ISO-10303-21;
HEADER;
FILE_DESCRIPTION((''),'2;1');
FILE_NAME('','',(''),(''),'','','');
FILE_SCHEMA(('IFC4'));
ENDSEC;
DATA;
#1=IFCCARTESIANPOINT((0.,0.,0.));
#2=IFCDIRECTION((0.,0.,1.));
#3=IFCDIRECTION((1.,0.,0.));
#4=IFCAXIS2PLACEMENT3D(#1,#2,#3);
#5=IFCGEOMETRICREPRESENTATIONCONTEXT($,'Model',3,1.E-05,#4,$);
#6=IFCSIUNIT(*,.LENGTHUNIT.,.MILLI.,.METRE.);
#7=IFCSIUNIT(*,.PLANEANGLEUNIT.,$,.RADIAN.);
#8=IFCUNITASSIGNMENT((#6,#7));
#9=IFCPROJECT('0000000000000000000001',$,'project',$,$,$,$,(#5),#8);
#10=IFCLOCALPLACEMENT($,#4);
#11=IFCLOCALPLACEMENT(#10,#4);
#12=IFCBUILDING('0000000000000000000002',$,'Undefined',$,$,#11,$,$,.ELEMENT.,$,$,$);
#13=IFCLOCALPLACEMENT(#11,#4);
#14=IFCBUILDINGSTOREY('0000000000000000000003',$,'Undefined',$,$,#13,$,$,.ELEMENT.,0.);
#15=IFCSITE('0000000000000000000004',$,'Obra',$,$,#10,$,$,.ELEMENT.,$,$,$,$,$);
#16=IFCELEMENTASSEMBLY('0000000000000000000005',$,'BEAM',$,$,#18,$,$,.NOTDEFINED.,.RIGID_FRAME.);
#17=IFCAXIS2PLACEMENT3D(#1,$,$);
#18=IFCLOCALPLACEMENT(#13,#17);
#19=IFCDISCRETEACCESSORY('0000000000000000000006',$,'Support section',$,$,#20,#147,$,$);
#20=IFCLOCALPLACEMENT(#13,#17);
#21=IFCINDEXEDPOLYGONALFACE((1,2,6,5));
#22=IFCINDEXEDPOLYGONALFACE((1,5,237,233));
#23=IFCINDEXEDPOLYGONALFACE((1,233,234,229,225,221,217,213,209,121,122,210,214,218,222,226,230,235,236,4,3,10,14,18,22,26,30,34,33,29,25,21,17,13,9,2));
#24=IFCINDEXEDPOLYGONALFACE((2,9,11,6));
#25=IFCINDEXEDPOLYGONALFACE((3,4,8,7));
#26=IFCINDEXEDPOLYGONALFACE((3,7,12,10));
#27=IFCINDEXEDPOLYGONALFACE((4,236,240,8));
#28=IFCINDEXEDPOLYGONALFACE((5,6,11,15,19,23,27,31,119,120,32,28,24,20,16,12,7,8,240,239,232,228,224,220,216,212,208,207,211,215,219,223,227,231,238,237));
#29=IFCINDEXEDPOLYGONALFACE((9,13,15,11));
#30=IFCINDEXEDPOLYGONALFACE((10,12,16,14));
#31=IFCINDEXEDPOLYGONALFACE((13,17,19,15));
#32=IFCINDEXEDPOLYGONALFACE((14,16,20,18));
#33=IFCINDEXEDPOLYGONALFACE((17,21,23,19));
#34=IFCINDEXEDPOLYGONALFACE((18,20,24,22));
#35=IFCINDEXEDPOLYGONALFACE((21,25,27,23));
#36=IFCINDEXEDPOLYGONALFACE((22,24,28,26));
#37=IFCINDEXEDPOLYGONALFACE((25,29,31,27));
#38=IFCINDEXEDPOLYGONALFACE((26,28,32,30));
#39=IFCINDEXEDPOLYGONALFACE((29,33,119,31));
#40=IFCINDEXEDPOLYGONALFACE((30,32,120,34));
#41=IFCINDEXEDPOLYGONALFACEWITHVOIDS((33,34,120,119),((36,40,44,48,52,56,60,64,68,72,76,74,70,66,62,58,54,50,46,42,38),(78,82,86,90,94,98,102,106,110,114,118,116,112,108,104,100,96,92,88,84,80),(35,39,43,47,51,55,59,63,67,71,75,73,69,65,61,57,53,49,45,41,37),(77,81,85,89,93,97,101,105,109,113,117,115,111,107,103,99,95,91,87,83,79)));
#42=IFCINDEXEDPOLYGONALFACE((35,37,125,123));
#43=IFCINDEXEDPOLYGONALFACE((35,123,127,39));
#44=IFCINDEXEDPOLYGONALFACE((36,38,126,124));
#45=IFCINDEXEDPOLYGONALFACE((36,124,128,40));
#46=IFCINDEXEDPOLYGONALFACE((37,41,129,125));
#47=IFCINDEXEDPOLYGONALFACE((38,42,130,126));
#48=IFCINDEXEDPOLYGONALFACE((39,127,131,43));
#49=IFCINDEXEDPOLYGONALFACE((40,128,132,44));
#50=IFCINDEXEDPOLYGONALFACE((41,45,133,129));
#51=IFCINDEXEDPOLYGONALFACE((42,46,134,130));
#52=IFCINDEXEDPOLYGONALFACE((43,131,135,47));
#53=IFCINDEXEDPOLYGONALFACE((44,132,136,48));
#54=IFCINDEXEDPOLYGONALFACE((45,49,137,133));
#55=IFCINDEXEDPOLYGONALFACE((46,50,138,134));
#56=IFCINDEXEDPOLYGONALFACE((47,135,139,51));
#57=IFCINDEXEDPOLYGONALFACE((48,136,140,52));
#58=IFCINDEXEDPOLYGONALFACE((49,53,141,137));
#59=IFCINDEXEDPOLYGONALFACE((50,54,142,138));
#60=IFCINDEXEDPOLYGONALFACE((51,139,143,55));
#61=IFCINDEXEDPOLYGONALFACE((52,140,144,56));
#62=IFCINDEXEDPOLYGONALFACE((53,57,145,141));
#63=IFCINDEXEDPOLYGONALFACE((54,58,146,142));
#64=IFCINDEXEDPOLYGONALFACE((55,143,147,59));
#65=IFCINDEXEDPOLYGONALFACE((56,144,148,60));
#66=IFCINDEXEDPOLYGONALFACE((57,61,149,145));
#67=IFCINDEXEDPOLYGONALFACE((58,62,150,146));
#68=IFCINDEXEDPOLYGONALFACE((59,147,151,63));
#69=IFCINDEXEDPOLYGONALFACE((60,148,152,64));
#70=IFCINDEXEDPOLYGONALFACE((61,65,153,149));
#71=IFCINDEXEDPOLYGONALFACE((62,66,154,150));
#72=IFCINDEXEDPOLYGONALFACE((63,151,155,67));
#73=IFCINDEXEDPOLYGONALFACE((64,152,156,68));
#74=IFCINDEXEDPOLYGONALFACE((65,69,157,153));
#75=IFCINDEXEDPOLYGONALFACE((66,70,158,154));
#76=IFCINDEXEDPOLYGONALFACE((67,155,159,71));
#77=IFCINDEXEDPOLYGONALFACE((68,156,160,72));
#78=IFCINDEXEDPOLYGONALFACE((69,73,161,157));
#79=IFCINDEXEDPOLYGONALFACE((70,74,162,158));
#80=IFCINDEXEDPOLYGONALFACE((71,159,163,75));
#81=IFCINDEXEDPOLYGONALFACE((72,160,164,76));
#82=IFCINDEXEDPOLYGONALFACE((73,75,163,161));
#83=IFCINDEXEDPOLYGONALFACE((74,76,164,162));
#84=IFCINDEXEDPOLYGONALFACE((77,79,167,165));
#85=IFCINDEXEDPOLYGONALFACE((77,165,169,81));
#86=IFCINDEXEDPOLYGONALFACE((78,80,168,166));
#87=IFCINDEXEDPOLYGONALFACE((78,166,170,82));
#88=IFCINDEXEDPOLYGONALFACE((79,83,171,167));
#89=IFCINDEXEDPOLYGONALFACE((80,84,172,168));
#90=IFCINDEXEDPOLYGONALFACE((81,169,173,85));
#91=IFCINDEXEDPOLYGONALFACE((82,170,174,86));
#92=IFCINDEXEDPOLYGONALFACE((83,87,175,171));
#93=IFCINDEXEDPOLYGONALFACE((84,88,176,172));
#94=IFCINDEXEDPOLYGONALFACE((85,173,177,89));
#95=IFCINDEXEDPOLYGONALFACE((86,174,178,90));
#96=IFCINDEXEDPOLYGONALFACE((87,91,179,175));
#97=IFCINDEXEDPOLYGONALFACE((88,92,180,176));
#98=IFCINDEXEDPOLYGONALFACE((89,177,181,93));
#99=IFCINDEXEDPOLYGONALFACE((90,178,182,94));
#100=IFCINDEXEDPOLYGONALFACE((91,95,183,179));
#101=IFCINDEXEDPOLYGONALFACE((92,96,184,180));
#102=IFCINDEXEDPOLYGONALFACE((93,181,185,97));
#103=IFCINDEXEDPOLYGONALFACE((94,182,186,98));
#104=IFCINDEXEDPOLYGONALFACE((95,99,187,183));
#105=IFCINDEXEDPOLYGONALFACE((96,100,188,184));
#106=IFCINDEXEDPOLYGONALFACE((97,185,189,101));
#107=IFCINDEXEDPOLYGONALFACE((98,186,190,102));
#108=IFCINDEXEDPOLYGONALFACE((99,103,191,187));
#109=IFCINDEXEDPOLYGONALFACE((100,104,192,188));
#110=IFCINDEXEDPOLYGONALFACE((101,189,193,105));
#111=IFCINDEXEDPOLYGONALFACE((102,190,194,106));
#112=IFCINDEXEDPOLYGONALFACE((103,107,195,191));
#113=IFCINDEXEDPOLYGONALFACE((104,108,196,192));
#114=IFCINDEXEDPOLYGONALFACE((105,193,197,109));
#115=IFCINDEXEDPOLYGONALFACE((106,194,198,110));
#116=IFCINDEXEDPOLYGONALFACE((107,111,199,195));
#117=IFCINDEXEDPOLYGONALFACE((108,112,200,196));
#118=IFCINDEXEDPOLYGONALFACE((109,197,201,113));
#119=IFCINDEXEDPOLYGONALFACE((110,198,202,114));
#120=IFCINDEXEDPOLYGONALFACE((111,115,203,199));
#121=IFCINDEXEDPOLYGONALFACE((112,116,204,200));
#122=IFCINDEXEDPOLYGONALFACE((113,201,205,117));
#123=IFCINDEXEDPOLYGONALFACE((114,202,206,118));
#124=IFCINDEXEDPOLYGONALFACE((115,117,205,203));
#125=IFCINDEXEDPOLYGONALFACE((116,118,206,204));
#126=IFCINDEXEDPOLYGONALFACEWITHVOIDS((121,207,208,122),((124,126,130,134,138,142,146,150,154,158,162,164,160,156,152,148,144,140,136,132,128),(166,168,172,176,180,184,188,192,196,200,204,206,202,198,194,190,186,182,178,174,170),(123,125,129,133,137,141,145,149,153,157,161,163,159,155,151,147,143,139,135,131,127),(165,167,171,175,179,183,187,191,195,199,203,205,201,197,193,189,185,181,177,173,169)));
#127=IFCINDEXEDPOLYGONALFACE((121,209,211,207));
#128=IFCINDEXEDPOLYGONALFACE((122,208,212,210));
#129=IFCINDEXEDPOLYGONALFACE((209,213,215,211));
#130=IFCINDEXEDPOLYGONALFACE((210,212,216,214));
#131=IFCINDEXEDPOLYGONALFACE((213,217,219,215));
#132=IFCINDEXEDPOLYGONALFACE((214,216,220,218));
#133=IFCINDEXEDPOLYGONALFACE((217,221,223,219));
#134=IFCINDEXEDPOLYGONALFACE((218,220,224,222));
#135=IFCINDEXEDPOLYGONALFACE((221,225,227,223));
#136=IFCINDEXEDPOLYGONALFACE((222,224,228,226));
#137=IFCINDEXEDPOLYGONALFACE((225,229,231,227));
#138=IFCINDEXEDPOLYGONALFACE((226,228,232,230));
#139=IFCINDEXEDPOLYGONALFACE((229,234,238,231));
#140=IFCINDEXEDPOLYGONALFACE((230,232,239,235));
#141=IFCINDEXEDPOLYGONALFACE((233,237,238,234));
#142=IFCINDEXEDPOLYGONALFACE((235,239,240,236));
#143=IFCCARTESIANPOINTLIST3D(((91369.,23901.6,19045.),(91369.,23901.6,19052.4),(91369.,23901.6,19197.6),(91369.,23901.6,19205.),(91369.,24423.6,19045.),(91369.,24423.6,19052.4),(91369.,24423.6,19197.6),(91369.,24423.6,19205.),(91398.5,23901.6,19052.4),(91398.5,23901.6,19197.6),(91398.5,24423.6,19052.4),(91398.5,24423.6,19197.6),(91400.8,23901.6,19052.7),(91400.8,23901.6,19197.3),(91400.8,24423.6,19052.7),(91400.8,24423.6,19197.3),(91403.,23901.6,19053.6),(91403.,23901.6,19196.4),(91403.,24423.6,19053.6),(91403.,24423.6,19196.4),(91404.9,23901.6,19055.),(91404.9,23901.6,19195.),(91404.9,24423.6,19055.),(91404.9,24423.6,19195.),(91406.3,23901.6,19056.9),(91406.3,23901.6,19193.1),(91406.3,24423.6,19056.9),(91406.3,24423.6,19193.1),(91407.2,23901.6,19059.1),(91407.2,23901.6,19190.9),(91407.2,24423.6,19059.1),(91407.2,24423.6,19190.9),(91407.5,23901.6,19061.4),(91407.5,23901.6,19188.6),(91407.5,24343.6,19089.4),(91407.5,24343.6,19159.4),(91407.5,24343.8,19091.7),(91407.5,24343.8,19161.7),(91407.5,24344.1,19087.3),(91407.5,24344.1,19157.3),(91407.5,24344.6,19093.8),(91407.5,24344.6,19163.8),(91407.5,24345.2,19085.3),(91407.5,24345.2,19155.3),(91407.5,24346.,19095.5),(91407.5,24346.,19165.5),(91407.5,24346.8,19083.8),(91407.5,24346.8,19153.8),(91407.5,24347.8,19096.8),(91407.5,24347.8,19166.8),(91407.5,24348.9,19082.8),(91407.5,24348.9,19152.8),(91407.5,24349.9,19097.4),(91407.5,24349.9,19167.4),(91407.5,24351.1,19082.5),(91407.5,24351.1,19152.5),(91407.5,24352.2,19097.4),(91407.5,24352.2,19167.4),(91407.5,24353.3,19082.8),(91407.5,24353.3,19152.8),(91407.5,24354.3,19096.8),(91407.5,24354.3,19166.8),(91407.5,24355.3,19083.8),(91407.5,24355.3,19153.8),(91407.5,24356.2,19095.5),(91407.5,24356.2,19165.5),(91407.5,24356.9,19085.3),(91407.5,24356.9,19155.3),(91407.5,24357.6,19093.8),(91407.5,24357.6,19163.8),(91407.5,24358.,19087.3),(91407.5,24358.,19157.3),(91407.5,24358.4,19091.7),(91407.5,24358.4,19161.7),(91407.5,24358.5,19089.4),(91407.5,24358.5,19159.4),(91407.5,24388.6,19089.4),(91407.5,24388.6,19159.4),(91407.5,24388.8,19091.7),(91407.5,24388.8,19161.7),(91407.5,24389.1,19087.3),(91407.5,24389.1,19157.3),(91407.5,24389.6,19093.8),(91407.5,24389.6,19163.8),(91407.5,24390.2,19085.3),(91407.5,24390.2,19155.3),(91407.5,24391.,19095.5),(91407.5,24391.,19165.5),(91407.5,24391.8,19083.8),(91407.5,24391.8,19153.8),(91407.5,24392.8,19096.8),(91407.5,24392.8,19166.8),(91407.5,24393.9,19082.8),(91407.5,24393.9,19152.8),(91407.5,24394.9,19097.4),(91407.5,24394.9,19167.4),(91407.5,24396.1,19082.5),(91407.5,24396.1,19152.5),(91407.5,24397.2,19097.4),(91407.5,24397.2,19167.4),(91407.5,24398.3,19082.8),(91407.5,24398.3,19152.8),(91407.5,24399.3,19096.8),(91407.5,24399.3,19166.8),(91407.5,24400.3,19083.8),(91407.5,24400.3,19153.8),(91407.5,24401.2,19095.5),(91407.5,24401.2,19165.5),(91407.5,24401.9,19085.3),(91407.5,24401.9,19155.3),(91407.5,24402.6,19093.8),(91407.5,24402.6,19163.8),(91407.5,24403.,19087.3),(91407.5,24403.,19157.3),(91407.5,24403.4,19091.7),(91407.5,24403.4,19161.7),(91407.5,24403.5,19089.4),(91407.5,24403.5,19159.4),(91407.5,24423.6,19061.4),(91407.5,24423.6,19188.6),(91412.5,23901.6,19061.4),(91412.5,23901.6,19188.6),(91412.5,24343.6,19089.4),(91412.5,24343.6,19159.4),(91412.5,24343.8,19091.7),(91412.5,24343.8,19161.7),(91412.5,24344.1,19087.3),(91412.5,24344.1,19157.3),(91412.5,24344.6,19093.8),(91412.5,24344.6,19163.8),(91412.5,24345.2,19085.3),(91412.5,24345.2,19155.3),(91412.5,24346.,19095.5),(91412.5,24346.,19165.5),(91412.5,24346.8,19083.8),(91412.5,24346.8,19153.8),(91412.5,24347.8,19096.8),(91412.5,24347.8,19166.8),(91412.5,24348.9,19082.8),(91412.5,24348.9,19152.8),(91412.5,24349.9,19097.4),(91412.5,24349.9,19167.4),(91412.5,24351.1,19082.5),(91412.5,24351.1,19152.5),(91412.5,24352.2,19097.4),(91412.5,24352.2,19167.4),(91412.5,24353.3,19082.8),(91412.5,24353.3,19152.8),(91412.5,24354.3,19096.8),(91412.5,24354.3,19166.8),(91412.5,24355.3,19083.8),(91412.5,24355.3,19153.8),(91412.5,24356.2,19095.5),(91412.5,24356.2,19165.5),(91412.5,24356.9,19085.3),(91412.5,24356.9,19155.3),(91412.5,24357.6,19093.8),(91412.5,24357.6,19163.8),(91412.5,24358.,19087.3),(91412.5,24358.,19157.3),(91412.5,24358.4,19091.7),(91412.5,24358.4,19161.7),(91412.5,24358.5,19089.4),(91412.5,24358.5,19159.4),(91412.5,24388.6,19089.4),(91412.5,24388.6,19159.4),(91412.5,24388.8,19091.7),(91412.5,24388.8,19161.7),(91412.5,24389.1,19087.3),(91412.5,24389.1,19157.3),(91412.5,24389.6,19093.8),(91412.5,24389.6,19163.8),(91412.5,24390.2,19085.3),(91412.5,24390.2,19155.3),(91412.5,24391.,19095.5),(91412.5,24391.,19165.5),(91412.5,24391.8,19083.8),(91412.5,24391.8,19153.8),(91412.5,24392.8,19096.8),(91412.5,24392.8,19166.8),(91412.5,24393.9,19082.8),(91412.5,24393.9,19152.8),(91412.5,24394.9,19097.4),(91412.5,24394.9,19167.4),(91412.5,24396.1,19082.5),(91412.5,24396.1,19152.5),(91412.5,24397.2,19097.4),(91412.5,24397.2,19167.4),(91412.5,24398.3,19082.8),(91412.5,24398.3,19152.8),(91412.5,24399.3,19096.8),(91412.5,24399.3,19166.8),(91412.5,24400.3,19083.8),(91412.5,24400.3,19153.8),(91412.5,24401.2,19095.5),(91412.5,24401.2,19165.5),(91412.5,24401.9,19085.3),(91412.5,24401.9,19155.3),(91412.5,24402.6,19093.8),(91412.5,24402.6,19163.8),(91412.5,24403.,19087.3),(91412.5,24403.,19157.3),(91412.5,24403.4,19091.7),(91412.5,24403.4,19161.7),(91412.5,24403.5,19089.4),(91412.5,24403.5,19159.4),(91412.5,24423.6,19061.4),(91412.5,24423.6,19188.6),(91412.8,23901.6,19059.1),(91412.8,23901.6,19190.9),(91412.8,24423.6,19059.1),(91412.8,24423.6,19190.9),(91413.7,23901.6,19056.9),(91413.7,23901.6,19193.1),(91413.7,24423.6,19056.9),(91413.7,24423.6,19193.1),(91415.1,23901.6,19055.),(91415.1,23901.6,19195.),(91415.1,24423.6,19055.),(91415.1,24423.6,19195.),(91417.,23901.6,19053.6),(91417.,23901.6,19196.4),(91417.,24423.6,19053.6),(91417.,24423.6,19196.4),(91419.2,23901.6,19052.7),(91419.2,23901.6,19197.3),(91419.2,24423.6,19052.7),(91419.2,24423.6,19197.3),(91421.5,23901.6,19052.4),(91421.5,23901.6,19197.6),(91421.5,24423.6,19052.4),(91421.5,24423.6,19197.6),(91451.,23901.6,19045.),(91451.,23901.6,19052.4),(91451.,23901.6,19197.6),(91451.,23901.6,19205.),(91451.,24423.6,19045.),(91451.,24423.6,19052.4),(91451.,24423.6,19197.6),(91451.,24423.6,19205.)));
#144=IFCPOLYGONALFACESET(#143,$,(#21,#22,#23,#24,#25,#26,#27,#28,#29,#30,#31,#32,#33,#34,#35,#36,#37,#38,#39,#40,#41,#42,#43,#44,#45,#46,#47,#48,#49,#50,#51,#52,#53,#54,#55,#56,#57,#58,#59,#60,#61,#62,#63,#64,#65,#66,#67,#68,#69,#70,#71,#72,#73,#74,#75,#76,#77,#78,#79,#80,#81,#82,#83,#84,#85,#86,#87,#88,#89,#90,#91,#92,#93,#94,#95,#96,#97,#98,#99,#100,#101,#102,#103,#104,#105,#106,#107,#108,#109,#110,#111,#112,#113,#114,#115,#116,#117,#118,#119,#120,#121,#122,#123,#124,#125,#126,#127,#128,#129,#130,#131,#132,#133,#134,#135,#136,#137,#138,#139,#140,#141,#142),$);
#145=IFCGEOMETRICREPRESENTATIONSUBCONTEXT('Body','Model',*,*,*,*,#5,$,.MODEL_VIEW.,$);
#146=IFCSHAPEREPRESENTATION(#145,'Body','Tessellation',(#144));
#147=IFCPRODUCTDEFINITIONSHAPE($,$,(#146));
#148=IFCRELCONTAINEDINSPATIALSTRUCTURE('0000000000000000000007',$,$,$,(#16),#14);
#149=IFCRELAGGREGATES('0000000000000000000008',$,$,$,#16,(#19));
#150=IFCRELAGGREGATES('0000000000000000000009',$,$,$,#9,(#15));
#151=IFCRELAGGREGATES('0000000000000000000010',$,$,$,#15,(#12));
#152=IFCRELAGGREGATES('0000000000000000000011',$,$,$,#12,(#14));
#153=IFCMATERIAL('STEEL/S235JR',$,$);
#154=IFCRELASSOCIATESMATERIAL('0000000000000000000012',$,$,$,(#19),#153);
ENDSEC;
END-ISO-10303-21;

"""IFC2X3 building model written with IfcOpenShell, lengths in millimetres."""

from ifc_helpers import new_model, si_unit, frame, origin_with_axes, origin_2d_with_axis, place, context, subcontext, project, spatial, circle, i_section, extrude, clip, halfspace, source, transform, mapped, material, element, aggregate, save


model = new_model("IFC2X3")

# Units and contexts
model_context = context("Model", 3, precision=1e-05, world=origin_with_axes())
body_context = subcontext(model_context, "Body", "Model", "MODEL_VIEW")
ifc_project = project(units=[si_unit("LENGTHUNIT", "METRE", prefix="MILLI"), si_unit("PLANEANGLEUNIT", "RADIAN")], contexts=[model_context])

# Site, building, storey
site_placement = place(None, origin_with_axes())
site = spatial("IfcSite", under=ifc_project, at=site_placement, Name="Obra", CompositionType="ELEMENT")
building_placement = place(site_placement, origin_with_axes())
building = spatial("IfcBuilding", under=site, at=building_placement, Name="Undefined", CompositionType="ELEMENT")
storey_placement = place(building_placement, origin_with_axes())
storey = spatial("IfcBuildingStorey", under=building, at=storey_placement, Name="Undefined", CompositionType="ELEMENT", Elevation=0.0)

# Shared definitions
ifc_material_1 = material(Name="STEEL/S235JR")

# Element assembly
assembly_1_placement = place(storey_placement, origin_with_axes())
assembly_1 = element("IfcElementAssembly", 1, at=assembly_1_placement, inside=storey, Name="BEAM", AssemblyPlace="NOTDEFINED", PredefinedType="RIGID_FRAME")

# Discrete accessory, opening
discrete_accessory_1_placement = place(assembly_1_placement, frame((91410.0, 23901.0, 19125.0), z_axis=(0.0, 0.0, 1.0), x_axis=(0.0, 1.0, 0.0)))
discrete_accessory_1 = element("IfcDiscreteAccessory", 2, at=discrete_accessory_1_placement, material=ifc_material_1, Name="Support section", context=body_context, shape_type="Clipping", body=[
    clip(clip(extrude(i_section(OverallWidth=82.0, OverallDepth=160.0, WebThickness=5.0, FlangeThickness=7.4, FilletRadius=9.0, at=origin_2d_with_axis()), frame((522.6, 0.0, 0.0), z_axis=(-1.0, 0.0, 0.0), x_axis=(0.0, -1.0, 0.0)), (0.0, 0.0, 1.0), 522.0), halfspace(frame((522.6, 0.0, -180.0), z_axis=(-1.0, 0.0, 0.0), x_axis=(0.0, 1.0, 0.0)), True)), halfspace(frame((0.6, 0.0, 580.0), z_axis=(-1.0, 0.0, 0.0), x_axis=(0.0, -1.0, 0.0)), False)),
])
shared_shape_1 = source(origin_with_axes(), body_context, "Body", "SweptSolid", [
    extrude(circle(Radius=7.5, at=origin_2d_with_axis()), frame((0.0, -2.6, 0.0), z_axis=(0.0, 1.0, 0.0), x_axis=(1.0, 0.0, 0.0)), (0.0, 0.0, 1.0), 5.2),
])
opening_1_placement = place(assembly_1_placement, frame((91410.0, 24373.6, 19160.0), z_axis=(0.0, -1.0, 0.0), x_axis=(0.0, 0.0, -1.0)))
element("IfcOpeningElement", 3, at=opening_1_placement, cuts=discrete_accessory_1, ObjectType="Opening", context=body_context, shape_type="MappedRepresentation", body=[
    mapped(shared_shape_1, transform((0.0, 0.0, -22.5))),
    mapped(shared_shape_1, transform((70.0, 0.0, -22.5))),
    mapped(shared_shape_1, transform((0.0, 0.0, 22.5))),
    mapped(shared_shape_1, transform((70.0, 0.0, 22.5))),
])
aggregate(assembly_1, [discrete_accessory_1])

save(model, "model.ifc")
